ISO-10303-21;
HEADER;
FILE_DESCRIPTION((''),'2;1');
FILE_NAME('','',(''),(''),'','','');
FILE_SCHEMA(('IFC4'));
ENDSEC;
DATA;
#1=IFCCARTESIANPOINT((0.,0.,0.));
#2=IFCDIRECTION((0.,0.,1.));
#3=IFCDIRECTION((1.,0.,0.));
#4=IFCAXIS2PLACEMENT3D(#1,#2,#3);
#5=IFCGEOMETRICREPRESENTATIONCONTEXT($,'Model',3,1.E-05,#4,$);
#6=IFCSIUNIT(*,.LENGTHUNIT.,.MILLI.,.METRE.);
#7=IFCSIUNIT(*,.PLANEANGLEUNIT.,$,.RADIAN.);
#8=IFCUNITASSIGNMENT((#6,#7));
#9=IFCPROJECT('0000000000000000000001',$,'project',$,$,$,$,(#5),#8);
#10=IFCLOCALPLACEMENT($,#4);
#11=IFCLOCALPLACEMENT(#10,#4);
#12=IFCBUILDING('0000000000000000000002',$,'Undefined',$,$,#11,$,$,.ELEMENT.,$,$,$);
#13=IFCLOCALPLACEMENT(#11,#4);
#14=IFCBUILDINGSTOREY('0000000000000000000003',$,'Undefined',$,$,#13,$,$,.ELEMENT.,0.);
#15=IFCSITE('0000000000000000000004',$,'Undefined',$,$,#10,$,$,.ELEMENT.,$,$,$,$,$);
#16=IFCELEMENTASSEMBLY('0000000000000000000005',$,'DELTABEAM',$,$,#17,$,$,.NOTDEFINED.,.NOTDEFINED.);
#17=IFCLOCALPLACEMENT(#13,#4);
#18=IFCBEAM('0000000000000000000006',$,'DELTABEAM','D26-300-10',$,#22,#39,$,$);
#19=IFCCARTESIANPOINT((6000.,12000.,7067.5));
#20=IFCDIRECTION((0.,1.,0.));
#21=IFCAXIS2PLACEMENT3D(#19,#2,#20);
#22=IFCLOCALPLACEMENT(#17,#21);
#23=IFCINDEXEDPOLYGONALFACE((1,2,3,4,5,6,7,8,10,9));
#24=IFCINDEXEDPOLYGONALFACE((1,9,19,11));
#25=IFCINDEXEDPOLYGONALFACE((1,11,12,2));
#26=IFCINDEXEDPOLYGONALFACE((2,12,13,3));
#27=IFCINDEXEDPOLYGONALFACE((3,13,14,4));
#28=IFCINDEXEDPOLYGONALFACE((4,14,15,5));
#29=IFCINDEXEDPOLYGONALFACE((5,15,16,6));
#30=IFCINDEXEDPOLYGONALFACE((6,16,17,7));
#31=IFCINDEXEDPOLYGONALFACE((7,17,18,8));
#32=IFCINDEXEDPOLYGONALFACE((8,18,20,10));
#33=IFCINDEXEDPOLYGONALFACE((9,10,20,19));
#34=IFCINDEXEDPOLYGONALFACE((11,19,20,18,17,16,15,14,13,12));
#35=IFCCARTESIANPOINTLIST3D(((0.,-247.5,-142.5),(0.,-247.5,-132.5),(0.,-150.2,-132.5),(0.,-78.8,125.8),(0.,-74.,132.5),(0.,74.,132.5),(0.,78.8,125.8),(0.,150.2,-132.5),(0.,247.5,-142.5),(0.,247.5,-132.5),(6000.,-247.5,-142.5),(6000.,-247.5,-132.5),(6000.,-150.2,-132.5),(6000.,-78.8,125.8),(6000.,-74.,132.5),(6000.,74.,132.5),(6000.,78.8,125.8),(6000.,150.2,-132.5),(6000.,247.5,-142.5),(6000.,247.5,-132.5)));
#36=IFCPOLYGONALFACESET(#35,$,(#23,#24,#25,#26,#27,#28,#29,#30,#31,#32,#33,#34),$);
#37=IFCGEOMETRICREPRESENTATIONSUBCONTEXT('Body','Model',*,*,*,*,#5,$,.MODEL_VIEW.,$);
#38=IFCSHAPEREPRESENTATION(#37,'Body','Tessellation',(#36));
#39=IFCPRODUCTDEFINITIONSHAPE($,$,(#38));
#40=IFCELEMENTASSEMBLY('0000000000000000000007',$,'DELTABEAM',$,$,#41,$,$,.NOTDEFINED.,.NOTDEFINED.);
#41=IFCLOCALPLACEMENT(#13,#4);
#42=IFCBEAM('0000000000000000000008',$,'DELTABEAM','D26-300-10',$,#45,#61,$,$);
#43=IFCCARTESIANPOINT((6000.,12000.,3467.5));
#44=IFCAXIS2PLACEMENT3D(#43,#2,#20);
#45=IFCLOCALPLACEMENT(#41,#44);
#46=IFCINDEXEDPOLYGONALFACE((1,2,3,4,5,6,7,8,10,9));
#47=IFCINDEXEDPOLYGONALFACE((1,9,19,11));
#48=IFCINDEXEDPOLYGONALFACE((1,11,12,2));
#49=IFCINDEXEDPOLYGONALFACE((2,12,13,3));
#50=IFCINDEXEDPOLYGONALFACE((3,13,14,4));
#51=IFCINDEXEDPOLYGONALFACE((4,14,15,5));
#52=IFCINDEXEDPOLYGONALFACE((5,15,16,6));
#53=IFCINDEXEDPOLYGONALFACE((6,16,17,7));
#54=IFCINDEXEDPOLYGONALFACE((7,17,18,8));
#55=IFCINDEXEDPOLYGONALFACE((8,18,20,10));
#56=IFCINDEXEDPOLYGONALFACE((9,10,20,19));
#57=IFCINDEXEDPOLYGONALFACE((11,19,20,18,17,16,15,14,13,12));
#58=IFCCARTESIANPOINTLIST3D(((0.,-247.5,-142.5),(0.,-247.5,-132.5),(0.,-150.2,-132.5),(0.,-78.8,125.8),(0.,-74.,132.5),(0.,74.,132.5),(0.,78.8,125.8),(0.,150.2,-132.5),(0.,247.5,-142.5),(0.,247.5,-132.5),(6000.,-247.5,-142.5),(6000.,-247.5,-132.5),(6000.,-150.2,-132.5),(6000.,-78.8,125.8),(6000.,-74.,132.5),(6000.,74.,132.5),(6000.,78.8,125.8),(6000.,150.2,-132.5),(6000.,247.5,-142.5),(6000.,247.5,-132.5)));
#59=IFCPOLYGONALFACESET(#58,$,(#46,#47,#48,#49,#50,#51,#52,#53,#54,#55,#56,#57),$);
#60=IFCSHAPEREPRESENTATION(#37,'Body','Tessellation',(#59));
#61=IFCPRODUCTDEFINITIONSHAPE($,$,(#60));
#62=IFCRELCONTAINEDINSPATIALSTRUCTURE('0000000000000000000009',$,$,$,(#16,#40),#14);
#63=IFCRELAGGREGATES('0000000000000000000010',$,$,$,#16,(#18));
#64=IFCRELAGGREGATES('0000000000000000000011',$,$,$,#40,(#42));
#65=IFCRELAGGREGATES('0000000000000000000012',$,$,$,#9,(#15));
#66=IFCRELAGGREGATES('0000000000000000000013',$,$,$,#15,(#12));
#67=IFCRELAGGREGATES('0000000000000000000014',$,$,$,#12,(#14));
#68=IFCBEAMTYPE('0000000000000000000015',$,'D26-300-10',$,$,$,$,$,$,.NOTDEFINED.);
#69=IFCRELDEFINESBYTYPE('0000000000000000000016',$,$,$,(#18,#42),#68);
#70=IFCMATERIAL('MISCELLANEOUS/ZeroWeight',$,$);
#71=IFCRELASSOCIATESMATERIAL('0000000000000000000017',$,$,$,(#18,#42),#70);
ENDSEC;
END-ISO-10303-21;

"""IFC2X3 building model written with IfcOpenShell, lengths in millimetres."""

from ifc_helpers import new_model, si_unit, frame, origin_with_axes, place, context, subcontext, project, spatial, polyline, outline, extrude, material, type_object, element, aggregate, save


model = new_model("IFC2X3")

# Units and contexts
model_context = context("Model", 3, precision=1e-05, world=origin_with_axes())
body_context = subcontext(model_context, "Body", "Model", "MODEL_VIEW")
ifc_project = project(units=[si_unit("LENGTHUNIT", "METRE", prefix="MILLI"), si_unit("PLANEANGLEUNIT", "RADIAN")], contexts=[model_context])

# Site, building, storey
site_placement = place(None, origin_with_axes())
site = spatial("IfcSite", under=ifc_project, at=site_placement, Name="Undefined", CompositionType="ELEMENT")
building_placement = place(site_placement, origin_with_axes())
building = spatial("IfcBuilding", under=site, at=building_placement, Name="Undefined", CompositionType="ELEMENT")
storey_placement = place(building_placement, origin_with_axes())
storey = spatial("IfcBuildingStorey", under=building, at=storey_placement, Name="Undefined", CompositionType="ELEMENT", Elevation=0.0)

# Element assemblies, beams
ifc_material_1 = material(Name="MISCELLANEOUS/ZeroWeight")
assembly_1_placement = place(storey_placement, origin_with_axes())
assembly_1 = element("IfcElementAssembly", 1, at=assembly_1_placement, inside=storey, Name="DELTABEAM", AssemblyPlace="NOTDEFINED", PredefinedType="NOTDEFINED")
beam_type_1 = type_object("IfcBeamType", Name="D26-300-10", PredefinedType="NOTDEFINED")
beam_1_placement = place(assembly_1_placement, frame((6000.0, 12000.0, 7067.5), z_axis=(0.0, 0.0, 1.0), x_axis=(0.0, 1.0, 0.0)))
beam_1 = element("IfcBeam", 2, at=beam_1_placement, type_object=beam_type_1, material=ifc_material_1, Name="DELTABEAM", Description="D26-300-10", context=body_context, shape_type="SweptSolid", body=[
    extrude(outline(polyline([(-75.1, 120.5), (-145.0, -132.5), (247.5, -132.5), (247.5, -142.5), (-247.5, -142.5), (-247.5, -132.5), (-150.2, -132.5), (-78.8, 125.8), (-74.0, 132.5), (74.0, 132.5), (78.8, 125.8), (150.2, -132.5), (145.0, -132.5), (75.1, 120.5), (-75.1, 120.5)])), frame((6000.0, 0.0, 0.0), z_axis=(-1.0, 0.0, 0.0), x_axis=(0.0, -1.0, 0.0)), (0.0, 0.0, 1.0), 6000.0),
])
aggregate(assembly_1, [beam_1])
assembly_2_placement = place(storey_placement, origin_with_axes())
assembly_2 = element("IfcElementAssembly", 3, at=assembly_2_placement, inside=storey, Name="DELTABEAM", AssemblyPlace="NOTDEFINED", PredefinedType="NOTDEFINED")
beam_2_placement = place(assembly_2_placement, frame((6000.0, 12000.0, 3467.5), z_axis=(0.0, 0.0, 1.0), x_axis=(0.0, 1.0, 0.0)))
beam_2 = element("IfcBeam", 4, at=beam_2_placement, type_object=beam_type_1, material=ifc_material_1, Name="DELTABEAM", Description="D26-300-10", context=body_context, shape_type="SweptSolid", body=[
    extrude(outline(polyline([(-75.1, 120.5), (-145.0, -132.5), (247.5, -132.5), (247.5, -142.5), (-247.5, -142.5), (-247.5, -132.5), (-150.2, -132.5), (-78.8, 125.8), (-74.0, 132.5), (74.0, 132.5), (78.8, 125.8), (150.2, -132.5), (145.0, -132.5), (75.1, 120.5), (-75.1, 120.5)])), frame((6000.0, 0.0, 0.0), z_axis=(-1.0, 0.0, 0.0), x_axis=(0.0, -1.0, 0.0)), (0.0, 0.0, 1.0), 6000.0),
])
aggregate(assembly_2, [beam_2])

save(model, "model.ifc")
